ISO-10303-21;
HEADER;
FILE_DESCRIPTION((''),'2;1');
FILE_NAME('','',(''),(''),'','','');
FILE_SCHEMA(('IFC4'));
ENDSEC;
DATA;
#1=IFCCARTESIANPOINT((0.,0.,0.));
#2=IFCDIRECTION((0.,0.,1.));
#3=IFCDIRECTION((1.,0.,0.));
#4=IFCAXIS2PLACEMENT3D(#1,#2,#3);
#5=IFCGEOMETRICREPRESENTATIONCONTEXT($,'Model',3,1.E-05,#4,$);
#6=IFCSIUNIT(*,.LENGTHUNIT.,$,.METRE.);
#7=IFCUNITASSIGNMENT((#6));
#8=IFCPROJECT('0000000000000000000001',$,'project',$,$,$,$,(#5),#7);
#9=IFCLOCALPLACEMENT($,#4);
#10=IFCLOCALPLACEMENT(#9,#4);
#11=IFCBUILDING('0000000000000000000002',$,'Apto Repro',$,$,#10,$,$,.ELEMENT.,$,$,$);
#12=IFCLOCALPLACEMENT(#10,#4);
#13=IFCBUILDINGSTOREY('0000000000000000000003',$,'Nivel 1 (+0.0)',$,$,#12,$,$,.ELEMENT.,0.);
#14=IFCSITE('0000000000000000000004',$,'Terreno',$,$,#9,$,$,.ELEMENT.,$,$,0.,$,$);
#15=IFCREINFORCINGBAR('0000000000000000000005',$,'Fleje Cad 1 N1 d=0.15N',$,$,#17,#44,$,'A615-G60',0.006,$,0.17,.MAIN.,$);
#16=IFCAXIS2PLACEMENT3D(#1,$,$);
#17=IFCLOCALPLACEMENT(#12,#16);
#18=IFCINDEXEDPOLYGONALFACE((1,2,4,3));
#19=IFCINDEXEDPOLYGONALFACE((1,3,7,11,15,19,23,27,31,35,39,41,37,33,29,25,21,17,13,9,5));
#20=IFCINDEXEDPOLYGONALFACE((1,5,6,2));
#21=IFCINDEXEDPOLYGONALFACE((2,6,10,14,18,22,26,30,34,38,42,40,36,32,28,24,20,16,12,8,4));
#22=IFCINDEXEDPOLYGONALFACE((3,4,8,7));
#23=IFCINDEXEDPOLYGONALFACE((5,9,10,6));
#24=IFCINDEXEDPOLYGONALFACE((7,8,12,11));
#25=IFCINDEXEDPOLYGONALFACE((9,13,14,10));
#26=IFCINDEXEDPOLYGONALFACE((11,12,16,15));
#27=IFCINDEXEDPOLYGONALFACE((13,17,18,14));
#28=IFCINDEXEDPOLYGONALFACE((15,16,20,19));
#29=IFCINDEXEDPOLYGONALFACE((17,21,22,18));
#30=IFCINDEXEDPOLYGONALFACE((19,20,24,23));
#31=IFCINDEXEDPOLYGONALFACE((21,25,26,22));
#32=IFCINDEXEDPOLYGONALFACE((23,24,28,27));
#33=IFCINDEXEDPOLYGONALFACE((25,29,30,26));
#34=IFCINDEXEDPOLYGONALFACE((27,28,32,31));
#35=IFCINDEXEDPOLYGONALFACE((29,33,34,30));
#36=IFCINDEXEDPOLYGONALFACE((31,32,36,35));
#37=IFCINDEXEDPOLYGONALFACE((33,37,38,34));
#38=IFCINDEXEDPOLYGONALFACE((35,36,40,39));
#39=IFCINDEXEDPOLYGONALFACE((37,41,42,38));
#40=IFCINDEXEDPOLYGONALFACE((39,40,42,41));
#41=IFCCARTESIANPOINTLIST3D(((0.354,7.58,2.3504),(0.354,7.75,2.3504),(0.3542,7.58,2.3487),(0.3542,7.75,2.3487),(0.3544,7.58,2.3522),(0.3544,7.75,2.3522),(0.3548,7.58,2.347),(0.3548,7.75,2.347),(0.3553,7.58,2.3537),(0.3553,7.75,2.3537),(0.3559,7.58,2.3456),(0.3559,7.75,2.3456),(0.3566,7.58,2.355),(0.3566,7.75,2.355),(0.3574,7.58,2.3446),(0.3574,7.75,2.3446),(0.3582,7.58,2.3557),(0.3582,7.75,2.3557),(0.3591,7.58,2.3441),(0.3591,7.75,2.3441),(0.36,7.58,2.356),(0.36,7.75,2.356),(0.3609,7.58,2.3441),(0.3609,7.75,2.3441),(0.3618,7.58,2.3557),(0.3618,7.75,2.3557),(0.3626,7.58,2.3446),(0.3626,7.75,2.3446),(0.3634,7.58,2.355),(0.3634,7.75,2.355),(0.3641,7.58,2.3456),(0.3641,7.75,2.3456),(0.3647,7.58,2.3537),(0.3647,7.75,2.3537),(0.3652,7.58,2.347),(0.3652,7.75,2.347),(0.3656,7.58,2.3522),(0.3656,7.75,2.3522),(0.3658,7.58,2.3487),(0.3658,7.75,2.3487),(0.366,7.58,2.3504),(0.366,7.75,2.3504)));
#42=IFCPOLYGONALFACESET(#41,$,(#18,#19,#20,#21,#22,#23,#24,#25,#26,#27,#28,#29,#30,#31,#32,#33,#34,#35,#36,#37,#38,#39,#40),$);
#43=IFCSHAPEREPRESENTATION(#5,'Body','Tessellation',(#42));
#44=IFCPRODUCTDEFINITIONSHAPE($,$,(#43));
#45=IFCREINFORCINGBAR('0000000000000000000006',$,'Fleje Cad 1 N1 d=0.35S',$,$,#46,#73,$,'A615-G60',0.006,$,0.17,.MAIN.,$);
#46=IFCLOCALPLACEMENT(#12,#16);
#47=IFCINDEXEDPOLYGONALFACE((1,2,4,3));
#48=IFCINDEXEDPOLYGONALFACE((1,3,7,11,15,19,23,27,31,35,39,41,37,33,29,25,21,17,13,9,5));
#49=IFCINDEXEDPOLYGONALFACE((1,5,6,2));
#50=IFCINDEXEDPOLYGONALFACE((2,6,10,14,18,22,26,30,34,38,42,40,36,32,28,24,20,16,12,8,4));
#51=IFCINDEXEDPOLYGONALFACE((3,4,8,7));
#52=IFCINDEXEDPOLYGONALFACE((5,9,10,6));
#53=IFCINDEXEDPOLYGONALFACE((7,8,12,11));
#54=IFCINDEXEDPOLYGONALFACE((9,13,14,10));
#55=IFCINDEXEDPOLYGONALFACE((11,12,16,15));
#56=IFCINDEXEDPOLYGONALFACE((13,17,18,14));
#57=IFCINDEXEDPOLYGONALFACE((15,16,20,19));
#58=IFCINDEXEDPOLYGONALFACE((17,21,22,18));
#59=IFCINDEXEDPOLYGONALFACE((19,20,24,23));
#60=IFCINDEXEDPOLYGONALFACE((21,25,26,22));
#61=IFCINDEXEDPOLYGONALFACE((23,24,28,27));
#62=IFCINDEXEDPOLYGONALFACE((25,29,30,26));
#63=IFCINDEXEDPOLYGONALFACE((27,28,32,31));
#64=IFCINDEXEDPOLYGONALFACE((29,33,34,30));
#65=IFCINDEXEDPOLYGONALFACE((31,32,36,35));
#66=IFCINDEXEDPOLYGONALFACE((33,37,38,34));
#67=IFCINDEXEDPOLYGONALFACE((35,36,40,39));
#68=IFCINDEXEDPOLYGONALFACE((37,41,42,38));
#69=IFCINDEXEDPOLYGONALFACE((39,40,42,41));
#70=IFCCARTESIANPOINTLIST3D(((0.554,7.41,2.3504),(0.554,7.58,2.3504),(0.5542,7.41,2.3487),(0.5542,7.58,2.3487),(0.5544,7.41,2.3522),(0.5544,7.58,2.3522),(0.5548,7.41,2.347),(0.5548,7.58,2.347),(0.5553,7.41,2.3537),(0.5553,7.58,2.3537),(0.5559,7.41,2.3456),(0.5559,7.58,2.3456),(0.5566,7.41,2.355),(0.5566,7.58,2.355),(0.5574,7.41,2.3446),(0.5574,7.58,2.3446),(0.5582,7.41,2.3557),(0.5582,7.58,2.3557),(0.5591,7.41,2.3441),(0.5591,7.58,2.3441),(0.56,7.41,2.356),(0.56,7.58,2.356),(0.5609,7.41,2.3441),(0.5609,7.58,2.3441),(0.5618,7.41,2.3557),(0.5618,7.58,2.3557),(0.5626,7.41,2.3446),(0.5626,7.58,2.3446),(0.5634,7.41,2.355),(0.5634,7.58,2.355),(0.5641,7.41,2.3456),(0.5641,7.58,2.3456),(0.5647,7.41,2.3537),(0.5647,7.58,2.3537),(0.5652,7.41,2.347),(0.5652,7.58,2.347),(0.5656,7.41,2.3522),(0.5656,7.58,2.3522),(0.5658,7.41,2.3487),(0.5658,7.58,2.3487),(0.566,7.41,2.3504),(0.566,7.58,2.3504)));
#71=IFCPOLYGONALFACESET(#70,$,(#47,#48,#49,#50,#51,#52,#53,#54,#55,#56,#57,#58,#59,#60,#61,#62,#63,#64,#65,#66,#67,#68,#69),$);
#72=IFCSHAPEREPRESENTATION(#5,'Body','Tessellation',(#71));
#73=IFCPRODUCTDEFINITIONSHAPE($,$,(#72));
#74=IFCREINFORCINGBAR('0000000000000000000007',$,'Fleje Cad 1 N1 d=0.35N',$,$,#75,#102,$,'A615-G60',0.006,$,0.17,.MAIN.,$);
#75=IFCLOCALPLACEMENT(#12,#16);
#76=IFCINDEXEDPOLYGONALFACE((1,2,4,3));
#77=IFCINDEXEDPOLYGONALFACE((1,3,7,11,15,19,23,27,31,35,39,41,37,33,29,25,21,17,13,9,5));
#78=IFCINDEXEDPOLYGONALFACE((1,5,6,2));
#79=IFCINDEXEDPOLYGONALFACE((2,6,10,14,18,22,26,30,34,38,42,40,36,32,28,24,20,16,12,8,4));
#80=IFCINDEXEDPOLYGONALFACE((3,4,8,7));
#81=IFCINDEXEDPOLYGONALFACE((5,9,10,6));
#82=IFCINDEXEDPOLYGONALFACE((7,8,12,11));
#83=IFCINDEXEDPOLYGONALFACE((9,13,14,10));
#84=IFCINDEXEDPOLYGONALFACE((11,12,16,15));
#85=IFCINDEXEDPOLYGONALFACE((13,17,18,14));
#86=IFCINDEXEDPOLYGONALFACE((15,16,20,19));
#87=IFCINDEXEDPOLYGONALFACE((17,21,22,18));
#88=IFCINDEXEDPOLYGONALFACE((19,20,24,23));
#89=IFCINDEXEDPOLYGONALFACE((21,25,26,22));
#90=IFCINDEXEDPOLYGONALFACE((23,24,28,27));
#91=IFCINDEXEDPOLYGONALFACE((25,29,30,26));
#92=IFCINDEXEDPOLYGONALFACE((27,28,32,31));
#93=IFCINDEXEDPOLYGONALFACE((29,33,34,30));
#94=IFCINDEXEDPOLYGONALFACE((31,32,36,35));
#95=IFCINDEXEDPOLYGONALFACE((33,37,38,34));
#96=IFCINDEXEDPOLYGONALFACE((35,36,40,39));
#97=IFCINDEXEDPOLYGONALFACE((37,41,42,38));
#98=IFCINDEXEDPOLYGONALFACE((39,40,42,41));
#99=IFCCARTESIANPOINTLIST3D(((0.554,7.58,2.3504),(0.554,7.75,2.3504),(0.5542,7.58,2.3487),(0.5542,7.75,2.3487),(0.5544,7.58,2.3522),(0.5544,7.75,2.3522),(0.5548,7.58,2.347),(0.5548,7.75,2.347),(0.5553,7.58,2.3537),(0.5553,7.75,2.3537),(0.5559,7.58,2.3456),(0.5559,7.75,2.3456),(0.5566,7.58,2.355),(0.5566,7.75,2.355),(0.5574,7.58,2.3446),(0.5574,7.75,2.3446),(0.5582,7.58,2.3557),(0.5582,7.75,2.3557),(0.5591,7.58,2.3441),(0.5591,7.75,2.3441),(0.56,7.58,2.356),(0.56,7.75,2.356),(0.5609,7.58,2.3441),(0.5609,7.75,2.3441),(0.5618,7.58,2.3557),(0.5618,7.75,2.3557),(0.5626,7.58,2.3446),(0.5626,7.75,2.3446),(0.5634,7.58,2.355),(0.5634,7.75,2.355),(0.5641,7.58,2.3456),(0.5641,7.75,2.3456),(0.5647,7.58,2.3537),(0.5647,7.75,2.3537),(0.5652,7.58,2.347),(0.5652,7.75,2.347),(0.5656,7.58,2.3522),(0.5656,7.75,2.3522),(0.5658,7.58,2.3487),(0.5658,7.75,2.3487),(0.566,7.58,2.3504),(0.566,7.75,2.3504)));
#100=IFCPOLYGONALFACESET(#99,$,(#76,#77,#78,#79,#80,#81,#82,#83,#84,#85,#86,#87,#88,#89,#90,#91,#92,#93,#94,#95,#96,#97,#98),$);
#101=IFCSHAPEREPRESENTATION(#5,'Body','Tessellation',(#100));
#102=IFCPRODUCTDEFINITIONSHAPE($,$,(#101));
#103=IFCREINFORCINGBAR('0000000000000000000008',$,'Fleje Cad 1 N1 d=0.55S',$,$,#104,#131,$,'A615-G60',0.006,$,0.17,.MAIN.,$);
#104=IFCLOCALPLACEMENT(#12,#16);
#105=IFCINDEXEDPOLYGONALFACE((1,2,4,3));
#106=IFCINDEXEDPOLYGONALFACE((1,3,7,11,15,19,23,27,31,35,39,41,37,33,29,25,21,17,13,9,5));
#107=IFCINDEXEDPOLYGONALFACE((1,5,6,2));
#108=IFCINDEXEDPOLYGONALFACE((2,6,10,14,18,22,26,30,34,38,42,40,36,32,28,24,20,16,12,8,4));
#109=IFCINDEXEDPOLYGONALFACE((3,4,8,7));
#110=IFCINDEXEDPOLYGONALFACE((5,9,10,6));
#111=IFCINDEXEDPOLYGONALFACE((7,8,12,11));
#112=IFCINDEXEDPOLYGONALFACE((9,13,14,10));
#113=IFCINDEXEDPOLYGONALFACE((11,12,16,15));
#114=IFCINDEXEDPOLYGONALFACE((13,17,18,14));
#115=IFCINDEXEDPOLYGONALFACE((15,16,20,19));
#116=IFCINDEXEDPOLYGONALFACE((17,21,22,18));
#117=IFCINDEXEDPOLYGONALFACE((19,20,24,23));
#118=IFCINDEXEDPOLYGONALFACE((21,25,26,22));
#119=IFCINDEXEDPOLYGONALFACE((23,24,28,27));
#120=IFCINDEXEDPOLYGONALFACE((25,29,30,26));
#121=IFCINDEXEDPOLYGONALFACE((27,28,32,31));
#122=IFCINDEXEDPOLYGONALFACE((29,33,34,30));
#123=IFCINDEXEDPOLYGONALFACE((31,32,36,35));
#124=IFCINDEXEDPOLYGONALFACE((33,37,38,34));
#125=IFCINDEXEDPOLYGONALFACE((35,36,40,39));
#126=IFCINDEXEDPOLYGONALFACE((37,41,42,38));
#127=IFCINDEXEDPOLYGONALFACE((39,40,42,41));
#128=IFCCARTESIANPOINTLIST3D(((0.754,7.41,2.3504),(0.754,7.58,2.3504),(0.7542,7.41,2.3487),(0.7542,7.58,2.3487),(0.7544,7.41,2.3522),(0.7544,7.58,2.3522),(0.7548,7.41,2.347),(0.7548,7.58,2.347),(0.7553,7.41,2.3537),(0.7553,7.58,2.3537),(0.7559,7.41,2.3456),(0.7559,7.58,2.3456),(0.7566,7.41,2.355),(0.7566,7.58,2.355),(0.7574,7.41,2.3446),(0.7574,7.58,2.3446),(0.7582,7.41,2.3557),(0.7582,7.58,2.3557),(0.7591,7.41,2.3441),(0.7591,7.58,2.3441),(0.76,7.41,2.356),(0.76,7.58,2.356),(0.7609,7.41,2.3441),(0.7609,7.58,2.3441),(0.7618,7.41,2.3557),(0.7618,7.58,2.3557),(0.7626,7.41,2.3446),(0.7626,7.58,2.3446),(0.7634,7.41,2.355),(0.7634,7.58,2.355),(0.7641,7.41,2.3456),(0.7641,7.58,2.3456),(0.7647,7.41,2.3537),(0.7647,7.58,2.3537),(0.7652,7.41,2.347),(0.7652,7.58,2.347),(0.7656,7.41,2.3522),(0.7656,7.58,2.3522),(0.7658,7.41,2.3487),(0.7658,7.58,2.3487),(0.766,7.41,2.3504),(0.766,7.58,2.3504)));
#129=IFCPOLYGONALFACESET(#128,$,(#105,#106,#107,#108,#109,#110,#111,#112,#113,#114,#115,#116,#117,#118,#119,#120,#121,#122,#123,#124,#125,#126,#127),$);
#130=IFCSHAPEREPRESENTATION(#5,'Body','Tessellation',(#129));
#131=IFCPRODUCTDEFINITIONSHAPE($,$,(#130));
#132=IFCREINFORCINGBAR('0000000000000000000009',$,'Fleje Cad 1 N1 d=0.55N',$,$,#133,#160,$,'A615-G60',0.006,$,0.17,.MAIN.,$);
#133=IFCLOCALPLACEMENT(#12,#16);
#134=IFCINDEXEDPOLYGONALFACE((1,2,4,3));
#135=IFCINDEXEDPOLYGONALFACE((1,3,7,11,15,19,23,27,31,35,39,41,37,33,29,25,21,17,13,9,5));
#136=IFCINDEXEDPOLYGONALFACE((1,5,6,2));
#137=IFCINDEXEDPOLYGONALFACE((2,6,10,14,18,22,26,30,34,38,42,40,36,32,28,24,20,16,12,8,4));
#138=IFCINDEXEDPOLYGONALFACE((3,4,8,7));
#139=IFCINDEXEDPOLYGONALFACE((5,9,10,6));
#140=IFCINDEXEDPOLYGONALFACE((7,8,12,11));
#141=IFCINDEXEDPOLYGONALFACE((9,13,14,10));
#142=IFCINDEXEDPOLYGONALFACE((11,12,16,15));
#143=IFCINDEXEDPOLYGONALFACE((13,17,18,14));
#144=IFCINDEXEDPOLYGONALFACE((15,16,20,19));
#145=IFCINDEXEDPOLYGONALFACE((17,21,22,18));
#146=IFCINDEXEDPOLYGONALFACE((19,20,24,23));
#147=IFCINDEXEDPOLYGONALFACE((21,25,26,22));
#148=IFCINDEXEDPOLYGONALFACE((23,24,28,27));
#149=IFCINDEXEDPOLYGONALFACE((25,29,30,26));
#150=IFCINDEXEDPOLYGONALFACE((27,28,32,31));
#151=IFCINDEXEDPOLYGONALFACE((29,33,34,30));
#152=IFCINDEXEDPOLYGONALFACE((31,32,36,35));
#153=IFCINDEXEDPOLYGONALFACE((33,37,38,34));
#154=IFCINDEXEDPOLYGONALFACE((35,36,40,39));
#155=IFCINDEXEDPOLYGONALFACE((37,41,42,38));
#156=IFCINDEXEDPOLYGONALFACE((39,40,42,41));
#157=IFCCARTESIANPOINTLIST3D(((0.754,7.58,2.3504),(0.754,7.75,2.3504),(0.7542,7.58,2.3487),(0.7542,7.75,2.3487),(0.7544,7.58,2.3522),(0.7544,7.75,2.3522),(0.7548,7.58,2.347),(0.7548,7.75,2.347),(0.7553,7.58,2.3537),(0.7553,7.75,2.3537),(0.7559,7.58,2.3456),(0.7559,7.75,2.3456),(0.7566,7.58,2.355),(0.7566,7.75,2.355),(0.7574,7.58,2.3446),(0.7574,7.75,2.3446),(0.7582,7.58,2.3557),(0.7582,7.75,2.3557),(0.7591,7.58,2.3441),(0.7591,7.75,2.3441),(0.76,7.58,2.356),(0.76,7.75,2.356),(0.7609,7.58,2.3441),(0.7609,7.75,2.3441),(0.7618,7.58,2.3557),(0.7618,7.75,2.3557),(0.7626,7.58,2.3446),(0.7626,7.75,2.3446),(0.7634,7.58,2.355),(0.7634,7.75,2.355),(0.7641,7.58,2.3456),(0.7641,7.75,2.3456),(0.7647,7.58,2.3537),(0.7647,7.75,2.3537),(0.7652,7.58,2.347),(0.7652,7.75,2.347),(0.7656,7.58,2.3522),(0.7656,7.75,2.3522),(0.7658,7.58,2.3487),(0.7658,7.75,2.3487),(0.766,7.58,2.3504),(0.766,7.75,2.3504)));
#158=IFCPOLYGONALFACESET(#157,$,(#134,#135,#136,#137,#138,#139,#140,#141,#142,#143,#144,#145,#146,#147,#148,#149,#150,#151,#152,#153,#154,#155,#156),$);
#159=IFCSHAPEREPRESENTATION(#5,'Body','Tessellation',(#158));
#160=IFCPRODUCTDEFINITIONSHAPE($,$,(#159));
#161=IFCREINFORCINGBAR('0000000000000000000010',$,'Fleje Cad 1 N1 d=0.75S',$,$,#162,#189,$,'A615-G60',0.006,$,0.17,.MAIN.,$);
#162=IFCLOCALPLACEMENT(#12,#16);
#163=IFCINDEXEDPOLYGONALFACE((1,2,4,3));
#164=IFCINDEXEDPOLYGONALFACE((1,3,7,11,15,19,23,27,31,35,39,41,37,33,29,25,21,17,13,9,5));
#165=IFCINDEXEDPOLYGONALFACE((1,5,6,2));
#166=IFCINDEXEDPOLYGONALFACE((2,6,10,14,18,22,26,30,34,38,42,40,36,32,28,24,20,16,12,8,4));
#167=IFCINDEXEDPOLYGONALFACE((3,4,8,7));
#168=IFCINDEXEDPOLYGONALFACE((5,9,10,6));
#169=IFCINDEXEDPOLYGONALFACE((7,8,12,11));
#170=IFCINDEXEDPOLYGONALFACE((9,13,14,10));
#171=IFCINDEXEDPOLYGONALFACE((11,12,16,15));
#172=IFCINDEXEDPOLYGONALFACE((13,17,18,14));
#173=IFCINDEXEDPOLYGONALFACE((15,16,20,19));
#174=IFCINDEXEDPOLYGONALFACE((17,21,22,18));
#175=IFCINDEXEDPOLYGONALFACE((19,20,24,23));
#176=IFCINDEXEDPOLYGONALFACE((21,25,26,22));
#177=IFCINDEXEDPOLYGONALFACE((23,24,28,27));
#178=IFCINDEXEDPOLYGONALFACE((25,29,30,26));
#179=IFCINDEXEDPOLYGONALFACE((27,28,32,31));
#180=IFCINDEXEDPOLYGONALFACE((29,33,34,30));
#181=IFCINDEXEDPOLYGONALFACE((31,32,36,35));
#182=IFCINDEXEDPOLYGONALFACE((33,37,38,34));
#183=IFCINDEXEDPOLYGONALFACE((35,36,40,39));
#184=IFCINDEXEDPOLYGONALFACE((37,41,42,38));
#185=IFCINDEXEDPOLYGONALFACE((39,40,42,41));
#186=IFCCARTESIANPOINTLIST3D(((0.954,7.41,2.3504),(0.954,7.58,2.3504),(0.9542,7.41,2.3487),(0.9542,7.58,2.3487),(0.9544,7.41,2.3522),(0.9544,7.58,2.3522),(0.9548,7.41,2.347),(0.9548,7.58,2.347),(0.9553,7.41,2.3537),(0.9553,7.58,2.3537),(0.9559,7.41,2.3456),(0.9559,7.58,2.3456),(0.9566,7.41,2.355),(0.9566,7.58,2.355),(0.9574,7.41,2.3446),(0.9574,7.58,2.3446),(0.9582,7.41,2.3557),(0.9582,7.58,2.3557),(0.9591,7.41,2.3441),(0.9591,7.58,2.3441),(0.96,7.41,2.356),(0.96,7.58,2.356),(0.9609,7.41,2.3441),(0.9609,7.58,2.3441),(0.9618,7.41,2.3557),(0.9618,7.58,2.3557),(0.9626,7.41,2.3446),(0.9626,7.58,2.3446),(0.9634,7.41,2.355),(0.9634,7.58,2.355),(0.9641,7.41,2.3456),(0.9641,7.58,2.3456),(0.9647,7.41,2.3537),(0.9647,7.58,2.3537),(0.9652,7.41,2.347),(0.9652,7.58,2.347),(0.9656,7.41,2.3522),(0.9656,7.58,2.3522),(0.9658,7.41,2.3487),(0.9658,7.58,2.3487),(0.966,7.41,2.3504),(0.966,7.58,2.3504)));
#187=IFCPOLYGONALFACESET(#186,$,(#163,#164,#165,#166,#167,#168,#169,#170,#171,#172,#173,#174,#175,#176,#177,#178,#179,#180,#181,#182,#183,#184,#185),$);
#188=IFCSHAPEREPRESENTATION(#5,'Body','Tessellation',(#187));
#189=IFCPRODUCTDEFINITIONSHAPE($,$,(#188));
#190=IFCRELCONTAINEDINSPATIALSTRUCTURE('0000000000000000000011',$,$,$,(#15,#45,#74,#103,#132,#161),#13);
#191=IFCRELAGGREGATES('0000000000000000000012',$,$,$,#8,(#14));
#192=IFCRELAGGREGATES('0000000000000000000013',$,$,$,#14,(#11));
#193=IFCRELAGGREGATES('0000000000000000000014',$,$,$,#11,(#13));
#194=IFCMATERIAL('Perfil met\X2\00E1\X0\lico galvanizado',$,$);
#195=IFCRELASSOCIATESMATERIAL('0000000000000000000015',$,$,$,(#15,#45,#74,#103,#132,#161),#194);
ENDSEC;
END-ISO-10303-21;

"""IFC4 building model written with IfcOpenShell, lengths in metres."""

from ifc_helpers import new_model, si_unit, frame, origin_with_axes, origin_2d_with_axis, place, context, project, spatial, circle, extrude, material, element, save


model = new_model("IFC4")

# Units and contexts
model_context = context("Model", 3, precision=1e-05, world=origin_with_axes())
ifc_project = project(units=[si_unit("LENGTHUNIT", "METRE")], contexts=[model_context])

# Site, building, storey
site_placement = place(None, origin_with_axes())
site = spatial("IfcSite", under=ifc_project, at=site_placement, Name="Terreno", CompositionType="ELEMENT", RefElevation=0.0)
building_placement = place(site_placement, origin_with_axes())
building = spatial("IfcBuilding", under=site, at=building_placement, Name="Apto Repro", CompositionType="ELEMENT")
storey_placement = place(building_placement, origin_with_axes())
storey = spatial("IfcBuildingStorey", under=building, at=storey_placement, Name="Nivel 1 (+0.0)", CompositionType="ELEMENT", Elevation=0.0)

# Reinforcing bars
ifc_material = material(Name="Perfil metálico galvanizado")
reinforcing_bar_1_placement = place(storey_placement, origin_with_axes())
element("IfcReinforcingBar", 1, at=reinforcing_bar_1_placement, inside=storey, material=ifc_material, Name="Fleje Cad 1 N1 d=0.15N", SteelGrade="A615-G60", BarLength=0.17, NominalDiameter=0.006, PredefinedType="MAIN", context=model_context, shape_type="SweptSolid", body=[
    extrude(circle(Radius=0.006, at=origin_2d_with_axis()), frame((0.36, 7.58, 2.35), z_axis=(0.0, 1.0, 0.0), x_axis=(0.0, 0.0, 1.0)), (0.0, 0.0, 1.0), 0.17),
])
reinforcing_bar_2_placement = place(storey_placement, origin_with_axes())
element("IfcReinforcingBar", 2, at=reinforcing_bar_2_placement, inside=storey, material=ifc_material, Name="Fleje Cad 1 N1 d=0.35S", SteelGrade="A615-G60", BarLength=0.17, NominalDiameter=0.006, PredefinedType="MAIN", context=model_context, shape_type="SweptSolid", body=[
    extrude(circle(Radius=0.006, at=origin_2d_with_axis()), frame((0.56, 7.41, 2.35), z_axis=(0.0, 1.0, 0.0), x_axis=(0.0, 0.0, 1.0)), (0.0, 0.0, 1.0), 0.17),
])
reinforcing_bar_3_placement = place(storey_placement, origin_with_axes())
element("IfcReinforcingBar", 3, at=reinforcing_bar_3_placement, inside=storey, material=ifc_material, Name="Fleje Cad 1 N1 d=0.35N", SteelGrade="A615-G60", BarLength=0.17, NominalDiameter=0.006, PredefinedType="MAIN", context=model_context, shape_type="SweptSolid", body=[
    extrude(circle(Radius=0.006, at=origin_2d_with_axis()), frame((0.56, 7.58, 2.35), z_axis=(0.0, 1.0, 0.0), x_axis=(0.0, 0.0, 1.0)), (0.0, 0.0, 1.0), 0.17),
])
reinforcing_bar_4_placement = place(storey_placement, origin_with_axes())
element("IfcReinforcingBar", 4, at=reinforcing_bar_4_placement, inside=storey, material=ifc_material, Name="Fleje Cad 1 N1 d=0.55S", SteelGrade="A615-G60", BarLength=0.17, NominalDiameter=0.006, PredefinedType="MAIN", context=model_context, shape_type="SweptSolid", body=[
    extrude(circle(Radius=0.006, at=origin_2d_with_axis()), frame((0.76, 7.41, 2.35), z_axis=(0.0, 1.0, 0.0), x_axis=(0.0, 0.0, 1.0)), (0.0, 0.0, 1.0), 0.17),
])
reinforcing_bar_5_placement = place(storey_placement, origin_with_axes())
element("IfcReinforcingBar", 5, at=reinforcing_bar_5_placement, inside=storey, material=ifc_material, Name="Fleje Cad 1 N1 d=0.55N", SteelGrade="A615-G60", BarLength=0.17, NominalDiameter=0.006, PredefinedType="MAIN", context=model_context, shape_type="SweptSolid", body=[
    extrude(circle(Radius=0.006, at=origin_2d_with_axis()), frame((0.76, 7.58, 2.35), z_axis=(0.0, 1.0, 0.0), x_axis=(0.0, 0.0, 1.0)), (0.0, 0.0, 1.0), 0.17),
])
reinforcing_bar_6_placement = place(storey_placement, origin_with_axes())
element("IfcReinforcingBar", 6, at=reinforcing_bar_6_placement, inside=storey, material=ifc_material, Name="Fleje Cad 1 N1 d=0.75S", SteelGrade="A615-G60", BarLength=0.17, NominalDiameter=0.006, PredefinedType="MAIN", context=model_context, shape_type="SweptSolid", body=[
    extrude(circle(Radius=0.006, at=origin_2d_with_axis()), frame((0.96, 7.41, 2.35), z_axis=(0.0, 1.0, 0.0), x_axis=(0.0, 0.0, 1.0)), (0.0, 0.0, 1.0), 0.17),
])

save(model, "model.ifc")
